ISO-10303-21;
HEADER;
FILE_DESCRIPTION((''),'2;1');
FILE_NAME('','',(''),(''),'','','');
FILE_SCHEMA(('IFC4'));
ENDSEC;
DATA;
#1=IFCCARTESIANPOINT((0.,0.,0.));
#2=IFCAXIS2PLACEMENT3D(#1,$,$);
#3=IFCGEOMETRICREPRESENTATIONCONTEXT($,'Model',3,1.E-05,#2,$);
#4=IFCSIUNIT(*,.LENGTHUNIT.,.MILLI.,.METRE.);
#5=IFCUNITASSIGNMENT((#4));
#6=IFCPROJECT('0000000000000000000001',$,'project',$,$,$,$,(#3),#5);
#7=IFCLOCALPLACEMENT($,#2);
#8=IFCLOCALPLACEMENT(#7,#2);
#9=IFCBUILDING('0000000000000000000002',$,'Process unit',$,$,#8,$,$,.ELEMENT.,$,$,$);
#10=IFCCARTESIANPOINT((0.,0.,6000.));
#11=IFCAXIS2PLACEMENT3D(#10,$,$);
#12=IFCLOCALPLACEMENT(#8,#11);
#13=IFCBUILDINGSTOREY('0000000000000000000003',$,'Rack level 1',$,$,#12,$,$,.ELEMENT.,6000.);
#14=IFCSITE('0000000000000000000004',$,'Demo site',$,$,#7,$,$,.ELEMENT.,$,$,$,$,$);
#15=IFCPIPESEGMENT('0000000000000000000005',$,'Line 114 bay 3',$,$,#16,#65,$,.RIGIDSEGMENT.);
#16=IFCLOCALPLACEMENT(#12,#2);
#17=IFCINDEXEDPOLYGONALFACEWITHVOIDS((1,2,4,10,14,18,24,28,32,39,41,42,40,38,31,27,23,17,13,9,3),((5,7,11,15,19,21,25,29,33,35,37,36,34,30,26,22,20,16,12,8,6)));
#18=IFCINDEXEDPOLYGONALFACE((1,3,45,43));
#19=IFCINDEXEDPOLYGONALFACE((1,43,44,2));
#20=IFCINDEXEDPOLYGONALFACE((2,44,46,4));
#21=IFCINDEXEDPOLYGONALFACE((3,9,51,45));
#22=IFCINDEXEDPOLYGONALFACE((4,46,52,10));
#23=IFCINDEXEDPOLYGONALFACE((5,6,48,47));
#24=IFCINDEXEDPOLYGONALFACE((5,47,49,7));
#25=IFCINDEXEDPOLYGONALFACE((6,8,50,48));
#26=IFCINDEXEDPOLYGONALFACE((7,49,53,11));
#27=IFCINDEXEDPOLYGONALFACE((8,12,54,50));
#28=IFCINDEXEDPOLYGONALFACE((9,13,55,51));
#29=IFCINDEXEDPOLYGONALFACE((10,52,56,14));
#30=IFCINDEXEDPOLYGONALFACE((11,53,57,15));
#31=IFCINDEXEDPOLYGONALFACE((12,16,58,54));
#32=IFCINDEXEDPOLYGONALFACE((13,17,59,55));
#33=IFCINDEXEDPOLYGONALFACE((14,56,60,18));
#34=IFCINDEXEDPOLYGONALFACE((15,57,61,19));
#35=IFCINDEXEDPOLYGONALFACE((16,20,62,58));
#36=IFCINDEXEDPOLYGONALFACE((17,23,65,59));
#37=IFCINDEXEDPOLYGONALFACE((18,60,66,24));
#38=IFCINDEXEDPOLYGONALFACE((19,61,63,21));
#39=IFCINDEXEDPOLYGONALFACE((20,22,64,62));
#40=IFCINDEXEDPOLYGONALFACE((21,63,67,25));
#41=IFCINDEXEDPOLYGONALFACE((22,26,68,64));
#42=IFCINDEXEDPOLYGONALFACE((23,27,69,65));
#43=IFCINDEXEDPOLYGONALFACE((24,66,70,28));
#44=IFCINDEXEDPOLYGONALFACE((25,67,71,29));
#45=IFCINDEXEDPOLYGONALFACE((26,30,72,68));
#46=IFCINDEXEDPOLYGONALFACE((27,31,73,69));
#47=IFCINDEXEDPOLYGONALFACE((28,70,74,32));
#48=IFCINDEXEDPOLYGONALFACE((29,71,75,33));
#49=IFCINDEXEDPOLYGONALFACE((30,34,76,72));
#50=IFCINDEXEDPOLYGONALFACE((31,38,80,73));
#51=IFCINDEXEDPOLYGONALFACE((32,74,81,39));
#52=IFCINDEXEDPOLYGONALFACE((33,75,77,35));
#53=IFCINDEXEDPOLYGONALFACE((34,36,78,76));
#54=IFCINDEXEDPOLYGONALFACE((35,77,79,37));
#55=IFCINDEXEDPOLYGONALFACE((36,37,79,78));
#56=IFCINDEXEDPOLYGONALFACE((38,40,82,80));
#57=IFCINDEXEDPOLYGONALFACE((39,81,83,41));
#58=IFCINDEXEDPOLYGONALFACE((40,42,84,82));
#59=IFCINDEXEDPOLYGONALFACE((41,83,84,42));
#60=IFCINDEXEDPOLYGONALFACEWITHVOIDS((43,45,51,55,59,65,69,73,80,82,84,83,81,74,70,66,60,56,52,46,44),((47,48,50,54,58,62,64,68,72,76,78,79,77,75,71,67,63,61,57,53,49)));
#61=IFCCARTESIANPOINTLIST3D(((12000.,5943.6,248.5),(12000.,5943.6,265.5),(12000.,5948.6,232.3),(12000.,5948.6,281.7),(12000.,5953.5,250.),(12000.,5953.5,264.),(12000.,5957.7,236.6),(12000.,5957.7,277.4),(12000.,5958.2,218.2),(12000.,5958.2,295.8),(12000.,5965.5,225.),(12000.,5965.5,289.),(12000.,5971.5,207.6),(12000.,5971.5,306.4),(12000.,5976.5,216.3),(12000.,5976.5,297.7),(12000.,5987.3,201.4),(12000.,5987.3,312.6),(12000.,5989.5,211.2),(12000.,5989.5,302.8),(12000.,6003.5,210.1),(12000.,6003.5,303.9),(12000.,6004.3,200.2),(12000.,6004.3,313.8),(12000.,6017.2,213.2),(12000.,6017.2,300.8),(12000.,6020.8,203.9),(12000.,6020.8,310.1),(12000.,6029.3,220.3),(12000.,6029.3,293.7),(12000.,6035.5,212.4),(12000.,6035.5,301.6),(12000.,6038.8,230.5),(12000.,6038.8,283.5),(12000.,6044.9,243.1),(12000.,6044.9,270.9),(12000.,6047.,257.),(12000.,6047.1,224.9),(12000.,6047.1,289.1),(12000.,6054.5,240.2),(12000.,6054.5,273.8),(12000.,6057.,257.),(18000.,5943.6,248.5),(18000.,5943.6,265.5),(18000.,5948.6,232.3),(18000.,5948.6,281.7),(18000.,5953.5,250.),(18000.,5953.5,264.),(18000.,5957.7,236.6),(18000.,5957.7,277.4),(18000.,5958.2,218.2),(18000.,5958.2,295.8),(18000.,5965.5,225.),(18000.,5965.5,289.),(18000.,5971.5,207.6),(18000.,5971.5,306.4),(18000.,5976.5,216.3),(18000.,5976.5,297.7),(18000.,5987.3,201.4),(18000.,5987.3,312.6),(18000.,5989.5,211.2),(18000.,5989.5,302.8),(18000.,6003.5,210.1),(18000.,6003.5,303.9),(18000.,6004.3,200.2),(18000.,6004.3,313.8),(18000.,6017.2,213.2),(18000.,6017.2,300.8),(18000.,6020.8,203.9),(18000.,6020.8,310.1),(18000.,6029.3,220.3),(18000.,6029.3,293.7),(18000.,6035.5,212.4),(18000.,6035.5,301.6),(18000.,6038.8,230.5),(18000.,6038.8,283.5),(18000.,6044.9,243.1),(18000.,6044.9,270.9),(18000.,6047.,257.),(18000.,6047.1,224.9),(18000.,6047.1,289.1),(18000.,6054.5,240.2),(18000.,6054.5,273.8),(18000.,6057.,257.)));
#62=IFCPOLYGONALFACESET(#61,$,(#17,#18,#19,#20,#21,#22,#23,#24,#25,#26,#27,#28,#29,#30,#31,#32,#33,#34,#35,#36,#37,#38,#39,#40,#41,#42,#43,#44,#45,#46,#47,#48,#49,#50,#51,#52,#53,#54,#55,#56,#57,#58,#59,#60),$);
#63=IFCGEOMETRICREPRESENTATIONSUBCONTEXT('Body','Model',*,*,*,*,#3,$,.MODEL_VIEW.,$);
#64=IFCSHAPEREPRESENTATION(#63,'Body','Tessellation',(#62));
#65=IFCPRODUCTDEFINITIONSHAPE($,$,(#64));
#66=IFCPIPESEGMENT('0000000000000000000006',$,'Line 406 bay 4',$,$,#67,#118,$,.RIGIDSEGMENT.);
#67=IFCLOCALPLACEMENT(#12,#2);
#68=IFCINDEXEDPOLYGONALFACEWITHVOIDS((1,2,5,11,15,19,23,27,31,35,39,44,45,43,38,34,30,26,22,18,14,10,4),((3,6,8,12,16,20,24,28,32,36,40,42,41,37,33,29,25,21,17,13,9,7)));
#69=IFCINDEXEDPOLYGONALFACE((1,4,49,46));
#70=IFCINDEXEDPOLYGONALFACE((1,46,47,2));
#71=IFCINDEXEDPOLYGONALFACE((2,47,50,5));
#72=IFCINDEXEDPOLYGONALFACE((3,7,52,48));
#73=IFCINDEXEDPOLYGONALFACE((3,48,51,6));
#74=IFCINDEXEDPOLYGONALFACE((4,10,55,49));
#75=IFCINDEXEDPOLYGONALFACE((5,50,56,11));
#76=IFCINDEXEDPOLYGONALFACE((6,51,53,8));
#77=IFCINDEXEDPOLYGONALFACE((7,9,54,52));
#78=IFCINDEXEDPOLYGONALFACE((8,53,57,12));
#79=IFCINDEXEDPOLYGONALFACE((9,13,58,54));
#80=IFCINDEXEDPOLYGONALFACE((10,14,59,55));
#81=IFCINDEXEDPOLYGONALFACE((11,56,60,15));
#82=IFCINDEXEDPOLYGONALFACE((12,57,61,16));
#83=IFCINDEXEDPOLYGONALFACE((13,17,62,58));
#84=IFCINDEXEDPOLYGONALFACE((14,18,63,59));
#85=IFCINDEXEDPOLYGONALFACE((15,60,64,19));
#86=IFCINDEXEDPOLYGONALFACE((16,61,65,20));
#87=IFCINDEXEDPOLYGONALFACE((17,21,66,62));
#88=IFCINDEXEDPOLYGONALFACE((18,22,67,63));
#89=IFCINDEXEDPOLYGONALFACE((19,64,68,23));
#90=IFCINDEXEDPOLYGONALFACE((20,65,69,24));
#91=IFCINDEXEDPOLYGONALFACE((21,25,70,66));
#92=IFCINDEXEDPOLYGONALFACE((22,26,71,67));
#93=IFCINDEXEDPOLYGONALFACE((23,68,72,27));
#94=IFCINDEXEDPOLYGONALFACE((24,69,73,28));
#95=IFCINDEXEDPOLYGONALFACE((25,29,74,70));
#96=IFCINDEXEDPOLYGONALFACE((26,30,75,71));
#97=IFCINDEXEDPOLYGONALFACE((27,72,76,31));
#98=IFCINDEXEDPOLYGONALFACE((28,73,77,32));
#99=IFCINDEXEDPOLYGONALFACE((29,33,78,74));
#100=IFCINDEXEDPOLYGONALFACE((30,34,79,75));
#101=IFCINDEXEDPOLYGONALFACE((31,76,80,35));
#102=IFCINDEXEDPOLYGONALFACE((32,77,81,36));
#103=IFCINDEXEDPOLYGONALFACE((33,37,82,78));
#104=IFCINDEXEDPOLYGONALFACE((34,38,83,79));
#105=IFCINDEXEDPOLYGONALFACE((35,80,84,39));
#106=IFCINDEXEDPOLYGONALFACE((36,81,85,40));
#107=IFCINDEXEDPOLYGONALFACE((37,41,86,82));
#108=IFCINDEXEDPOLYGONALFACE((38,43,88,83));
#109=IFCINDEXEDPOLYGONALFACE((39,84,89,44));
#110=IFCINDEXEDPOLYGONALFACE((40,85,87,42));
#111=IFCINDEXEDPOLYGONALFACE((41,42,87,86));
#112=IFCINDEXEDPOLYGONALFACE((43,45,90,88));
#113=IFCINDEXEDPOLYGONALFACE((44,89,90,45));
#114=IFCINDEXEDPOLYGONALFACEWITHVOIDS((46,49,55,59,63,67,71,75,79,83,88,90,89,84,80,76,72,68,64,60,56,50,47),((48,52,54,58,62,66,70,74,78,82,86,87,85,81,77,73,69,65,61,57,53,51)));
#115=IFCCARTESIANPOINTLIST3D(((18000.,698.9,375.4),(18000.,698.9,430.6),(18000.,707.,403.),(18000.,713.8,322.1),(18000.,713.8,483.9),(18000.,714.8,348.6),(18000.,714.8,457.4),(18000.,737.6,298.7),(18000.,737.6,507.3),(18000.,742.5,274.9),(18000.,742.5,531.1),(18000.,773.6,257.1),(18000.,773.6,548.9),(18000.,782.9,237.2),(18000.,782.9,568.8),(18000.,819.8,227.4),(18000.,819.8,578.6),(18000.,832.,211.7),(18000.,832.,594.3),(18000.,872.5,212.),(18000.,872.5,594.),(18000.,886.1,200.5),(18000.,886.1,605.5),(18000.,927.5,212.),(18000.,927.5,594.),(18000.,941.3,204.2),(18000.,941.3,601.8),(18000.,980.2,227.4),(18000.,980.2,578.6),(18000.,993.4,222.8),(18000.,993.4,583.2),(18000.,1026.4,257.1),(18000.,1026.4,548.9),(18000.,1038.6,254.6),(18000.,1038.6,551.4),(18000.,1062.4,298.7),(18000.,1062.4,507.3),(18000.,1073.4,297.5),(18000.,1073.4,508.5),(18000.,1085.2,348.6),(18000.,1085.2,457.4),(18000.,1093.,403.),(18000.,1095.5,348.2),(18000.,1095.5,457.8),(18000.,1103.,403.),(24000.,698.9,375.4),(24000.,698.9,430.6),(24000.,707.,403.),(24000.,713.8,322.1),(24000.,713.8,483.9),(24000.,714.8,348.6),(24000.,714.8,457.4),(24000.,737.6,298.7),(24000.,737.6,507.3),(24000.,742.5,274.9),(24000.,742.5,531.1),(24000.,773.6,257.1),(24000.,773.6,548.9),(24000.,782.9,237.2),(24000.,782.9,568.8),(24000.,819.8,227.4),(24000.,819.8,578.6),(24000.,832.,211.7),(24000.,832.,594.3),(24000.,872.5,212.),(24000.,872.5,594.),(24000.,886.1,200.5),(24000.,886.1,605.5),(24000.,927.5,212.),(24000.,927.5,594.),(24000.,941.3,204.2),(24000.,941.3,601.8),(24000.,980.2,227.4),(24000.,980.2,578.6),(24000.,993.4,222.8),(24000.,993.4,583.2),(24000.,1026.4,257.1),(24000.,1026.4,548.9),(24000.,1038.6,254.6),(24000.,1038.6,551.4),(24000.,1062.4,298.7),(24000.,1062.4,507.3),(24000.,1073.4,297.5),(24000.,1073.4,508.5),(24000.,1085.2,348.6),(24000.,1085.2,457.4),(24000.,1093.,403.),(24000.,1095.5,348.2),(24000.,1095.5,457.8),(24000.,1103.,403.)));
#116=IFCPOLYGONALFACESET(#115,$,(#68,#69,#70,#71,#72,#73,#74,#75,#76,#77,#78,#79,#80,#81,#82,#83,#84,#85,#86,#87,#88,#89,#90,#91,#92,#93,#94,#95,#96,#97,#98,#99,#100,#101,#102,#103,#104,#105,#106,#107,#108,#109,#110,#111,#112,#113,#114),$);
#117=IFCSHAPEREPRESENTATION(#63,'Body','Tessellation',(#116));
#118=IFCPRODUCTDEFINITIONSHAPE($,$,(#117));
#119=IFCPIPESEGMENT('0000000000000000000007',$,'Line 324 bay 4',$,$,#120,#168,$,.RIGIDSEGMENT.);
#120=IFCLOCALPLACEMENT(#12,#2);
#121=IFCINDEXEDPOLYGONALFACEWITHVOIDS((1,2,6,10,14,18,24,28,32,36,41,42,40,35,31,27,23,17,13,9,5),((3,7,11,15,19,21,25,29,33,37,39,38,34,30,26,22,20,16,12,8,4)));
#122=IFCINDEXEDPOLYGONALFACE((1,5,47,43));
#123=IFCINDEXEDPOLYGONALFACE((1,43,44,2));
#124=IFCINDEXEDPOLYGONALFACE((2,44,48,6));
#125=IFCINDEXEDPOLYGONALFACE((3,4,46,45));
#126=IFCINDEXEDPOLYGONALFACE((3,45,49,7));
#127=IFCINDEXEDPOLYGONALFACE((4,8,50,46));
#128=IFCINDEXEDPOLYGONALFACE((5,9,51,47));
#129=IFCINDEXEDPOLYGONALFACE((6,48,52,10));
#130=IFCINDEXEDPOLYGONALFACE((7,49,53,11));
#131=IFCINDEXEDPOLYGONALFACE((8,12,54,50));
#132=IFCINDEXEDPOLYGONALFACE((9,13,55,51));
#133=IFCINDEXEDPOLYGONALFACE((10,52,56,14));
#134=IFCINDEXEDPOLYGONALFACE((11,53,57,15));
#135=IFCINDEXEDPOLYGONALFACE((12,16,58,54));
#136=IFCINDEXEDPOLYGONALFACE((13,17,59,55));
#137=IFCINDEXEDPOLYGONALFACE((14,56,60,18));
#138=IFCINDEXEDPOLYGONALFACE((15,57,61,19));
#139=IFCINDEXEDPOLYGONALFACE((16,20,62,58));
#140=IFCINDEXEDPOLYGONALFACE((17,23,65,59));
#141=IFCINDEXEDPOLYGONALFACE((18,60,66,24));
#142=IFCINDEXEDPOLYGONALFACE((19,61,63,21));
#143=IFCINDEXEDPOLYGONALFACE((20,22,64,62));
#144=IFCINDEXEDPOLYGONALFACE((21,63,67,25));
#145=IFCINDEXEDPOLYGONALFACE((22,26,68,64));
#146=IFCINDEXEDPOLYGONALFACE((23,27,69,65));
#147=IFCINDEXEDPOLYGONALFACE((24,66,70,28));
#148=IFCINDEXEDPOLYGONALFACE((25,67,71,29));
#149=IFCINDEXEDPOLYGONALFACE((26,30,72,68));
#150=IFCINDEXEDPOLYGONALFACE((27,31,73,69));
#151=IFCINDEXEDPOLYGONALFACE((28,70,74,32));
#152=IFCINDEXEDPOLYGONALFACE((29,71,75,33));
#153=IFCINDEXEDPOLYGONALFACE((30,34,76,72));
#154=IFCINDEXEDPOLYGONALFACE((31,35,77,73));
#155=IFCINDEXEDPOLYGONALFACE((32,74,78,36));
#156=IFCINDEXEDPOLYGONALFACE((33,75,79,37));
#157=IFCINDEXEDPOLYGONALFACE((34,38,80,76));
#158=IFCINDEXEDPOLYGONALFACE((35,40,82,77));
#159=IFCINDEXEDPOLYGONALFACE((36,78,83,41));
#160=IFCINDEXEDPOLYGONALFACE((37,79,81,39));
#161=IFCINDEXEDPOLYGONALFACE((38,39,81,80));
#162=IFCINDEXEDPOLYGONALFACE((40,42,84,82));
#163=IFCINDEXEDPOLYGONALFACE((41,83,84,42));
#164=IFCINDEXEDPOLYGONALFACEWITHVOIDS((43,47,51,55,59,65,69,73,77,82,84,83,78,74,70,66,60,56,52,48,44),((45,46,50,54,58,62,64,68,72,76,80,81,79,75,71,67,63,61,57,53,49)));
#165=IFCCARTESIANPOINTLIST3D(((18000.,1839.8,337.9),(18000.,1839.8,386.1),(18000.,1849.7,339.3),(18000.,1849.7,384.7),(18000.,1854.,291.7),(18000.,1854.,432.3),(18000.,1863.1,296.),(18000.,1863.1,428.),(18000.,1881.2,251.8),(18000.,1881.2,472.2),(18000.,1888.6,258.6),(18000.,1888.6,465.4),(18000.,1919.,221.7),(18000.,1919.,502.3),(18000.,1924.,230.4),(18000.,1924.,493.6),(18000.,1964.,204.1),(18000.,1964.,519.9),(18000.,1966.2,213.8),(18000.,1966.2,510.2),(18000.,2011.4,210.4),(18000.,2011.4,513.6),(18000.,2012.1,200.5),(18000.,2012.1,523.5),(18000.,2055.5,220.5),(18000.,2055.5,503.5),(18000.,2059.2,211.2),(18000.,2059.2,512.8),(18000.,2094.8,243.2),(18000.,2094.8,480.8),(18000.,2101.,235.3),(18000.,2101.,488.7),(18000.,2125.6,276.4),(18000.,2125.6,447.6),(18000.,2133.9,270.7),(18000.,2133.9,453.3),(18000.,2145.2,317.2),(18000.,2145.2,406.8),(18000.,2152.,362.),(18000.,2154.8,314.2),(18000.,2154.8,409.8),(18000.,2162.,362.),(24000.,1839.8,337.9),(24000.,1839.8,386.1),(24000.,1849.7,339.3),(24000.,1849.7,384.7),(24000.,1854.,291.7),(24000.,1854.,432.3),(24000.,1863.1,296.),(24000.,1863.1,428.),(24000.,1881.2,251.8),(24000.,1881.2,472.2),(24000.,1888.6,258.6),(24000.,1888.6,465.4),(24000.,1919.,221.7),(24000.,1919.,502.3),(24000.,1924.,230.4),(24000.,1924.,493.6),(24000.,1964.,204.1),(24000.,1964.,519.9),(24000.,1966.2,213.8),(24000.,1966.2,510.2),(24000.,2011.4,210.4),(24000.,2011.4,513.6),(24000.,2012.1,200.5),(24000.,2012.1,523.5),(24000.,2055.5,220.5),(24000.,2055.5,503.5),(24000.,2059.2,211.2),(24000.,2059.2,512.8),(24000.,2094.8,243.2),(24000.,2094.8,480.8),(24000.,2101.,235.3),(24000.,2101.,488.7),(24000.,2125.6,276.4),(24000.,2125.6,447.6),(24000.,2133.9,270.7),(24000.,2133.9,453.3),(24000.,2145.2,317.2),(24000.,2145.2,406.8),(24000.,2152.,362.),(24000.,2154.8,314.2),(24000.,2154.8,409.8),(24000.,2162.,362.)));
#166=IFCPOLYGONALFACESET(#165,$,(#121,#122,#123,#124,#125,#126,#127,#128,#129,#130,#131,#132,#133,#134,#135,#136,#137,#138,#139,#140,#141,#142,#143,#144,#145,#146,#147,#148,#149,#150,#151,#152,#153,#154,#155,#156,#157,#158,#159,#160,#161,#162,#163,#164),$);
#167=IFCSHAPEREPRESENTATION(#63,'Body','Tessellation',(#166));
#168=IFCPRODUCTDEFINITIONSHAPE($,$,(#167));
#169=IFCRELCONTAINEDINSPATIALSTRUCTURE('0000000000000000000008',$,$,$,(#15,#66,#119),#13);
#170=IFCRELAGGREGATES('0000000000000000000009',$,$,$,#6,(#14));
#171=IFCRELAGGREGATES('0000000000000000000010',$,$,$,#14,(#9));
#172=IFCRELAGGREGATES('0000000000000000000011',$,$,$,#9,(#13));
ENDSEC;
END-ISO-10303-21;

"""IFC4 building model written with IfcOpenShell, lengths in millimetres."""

from ifc_helpers import new_model, si_unit, frame, origin, place, context, subcontext, project, spatial, hollow_circle, extrude, element, save


model = new_model("IFC4")

# Units and contexts
model_context = context("Model", 3, precision=1e-05, world=origin())
body_context = subcontext(model_context, "Body", "Model", "MODEL_VIEW")
ifc_project = project(units=[si_unit("LENGTHUNIT", "METRE", prefix="MILLI")], contexts=[model_context])

# Site, building, storey
site_placement = place(None, origin())
site = spatial("IfcSite", under=ifc_project, at=site_placement, Name="Demo site", CompositionType="ELEMENT")
building_placement = place(site_placement, origin())
building = spatial("IfcBuilding", under=site, at=building_placement, Name="Process unit", CompositionType="ELEMENT")
storey_placement = place(building_placement, frame((0.0, 0.0, 6000.0)))
storey = spatial("IfcBuildingStorey", under=building, at=storey_placement, Name="Rack level 1", CompositionType="ELEMENT", Elevation=6000.0)

# Pipe segments
pipe_segment_1_placement = place(storey_placement, frame((12000.0, 6000.0, 257.0)))
element("IfcPipeSegment", 1, at=pipe_segment_1_placement, inside=storey, Name="Line 114 bay 3", PredefinedType="RIGIDSEGMENT", context=body_context, shape_type="SweptSolid", body=[
    extrude(hollow_circle(Radius=57.0, WallThickness=10.0), frame((0.0, 0.0, 0.0), z_axis=(1.0, 0.0, 0.0), x_axis=(0.0, 1.0, 0.0)), (0.0, 0.0, 1.0), 6000.0),
])
pipe_segment_2_placement = place(storey_placement, frame((18000.0, 900.0, 403.0)))
element("IfcPipeSegment", 2, at=pipe_segment_2_placement, inside=storey, Name="Line 406 bay 4", PredefinedType="RIGIDSEGMENT", context=body_context, shape_type="SweptSolid", body=[
    extrude(hollow_circle(Radius=203.0, WallThickness=10.0), frame((0.0, 0.0, 0.0), z_axis=(1.0, 0.0, 0.0), x_axis=(0.0, 1.0, 0.0)), (0.0, 0.0, 1.0), 6000.0),
])
pipe_segment_3_placement = place(storey_placement, frame((18000.0, 2000.0, 362.0)))
element("IfcPipeSegment", 3, at=pipe_segment_3_placement, inside=storey, Name="Line 324 bay 4", PredefinedType="RIGIDSEGMENT", context=body_context, shape_type="SweptSolid", body=[
    extrude(hollow_circle(Radius=162.0, WallThickness=10.0), frame((0.0, 0.0, 0.0), z_axis=(1.0, 0.0, 0.0), x_axis=(0.0, 1.0, 0.0)), (0.0, 0.0, 1.0), 6000.0),
])

save(model, "model.ifc")
